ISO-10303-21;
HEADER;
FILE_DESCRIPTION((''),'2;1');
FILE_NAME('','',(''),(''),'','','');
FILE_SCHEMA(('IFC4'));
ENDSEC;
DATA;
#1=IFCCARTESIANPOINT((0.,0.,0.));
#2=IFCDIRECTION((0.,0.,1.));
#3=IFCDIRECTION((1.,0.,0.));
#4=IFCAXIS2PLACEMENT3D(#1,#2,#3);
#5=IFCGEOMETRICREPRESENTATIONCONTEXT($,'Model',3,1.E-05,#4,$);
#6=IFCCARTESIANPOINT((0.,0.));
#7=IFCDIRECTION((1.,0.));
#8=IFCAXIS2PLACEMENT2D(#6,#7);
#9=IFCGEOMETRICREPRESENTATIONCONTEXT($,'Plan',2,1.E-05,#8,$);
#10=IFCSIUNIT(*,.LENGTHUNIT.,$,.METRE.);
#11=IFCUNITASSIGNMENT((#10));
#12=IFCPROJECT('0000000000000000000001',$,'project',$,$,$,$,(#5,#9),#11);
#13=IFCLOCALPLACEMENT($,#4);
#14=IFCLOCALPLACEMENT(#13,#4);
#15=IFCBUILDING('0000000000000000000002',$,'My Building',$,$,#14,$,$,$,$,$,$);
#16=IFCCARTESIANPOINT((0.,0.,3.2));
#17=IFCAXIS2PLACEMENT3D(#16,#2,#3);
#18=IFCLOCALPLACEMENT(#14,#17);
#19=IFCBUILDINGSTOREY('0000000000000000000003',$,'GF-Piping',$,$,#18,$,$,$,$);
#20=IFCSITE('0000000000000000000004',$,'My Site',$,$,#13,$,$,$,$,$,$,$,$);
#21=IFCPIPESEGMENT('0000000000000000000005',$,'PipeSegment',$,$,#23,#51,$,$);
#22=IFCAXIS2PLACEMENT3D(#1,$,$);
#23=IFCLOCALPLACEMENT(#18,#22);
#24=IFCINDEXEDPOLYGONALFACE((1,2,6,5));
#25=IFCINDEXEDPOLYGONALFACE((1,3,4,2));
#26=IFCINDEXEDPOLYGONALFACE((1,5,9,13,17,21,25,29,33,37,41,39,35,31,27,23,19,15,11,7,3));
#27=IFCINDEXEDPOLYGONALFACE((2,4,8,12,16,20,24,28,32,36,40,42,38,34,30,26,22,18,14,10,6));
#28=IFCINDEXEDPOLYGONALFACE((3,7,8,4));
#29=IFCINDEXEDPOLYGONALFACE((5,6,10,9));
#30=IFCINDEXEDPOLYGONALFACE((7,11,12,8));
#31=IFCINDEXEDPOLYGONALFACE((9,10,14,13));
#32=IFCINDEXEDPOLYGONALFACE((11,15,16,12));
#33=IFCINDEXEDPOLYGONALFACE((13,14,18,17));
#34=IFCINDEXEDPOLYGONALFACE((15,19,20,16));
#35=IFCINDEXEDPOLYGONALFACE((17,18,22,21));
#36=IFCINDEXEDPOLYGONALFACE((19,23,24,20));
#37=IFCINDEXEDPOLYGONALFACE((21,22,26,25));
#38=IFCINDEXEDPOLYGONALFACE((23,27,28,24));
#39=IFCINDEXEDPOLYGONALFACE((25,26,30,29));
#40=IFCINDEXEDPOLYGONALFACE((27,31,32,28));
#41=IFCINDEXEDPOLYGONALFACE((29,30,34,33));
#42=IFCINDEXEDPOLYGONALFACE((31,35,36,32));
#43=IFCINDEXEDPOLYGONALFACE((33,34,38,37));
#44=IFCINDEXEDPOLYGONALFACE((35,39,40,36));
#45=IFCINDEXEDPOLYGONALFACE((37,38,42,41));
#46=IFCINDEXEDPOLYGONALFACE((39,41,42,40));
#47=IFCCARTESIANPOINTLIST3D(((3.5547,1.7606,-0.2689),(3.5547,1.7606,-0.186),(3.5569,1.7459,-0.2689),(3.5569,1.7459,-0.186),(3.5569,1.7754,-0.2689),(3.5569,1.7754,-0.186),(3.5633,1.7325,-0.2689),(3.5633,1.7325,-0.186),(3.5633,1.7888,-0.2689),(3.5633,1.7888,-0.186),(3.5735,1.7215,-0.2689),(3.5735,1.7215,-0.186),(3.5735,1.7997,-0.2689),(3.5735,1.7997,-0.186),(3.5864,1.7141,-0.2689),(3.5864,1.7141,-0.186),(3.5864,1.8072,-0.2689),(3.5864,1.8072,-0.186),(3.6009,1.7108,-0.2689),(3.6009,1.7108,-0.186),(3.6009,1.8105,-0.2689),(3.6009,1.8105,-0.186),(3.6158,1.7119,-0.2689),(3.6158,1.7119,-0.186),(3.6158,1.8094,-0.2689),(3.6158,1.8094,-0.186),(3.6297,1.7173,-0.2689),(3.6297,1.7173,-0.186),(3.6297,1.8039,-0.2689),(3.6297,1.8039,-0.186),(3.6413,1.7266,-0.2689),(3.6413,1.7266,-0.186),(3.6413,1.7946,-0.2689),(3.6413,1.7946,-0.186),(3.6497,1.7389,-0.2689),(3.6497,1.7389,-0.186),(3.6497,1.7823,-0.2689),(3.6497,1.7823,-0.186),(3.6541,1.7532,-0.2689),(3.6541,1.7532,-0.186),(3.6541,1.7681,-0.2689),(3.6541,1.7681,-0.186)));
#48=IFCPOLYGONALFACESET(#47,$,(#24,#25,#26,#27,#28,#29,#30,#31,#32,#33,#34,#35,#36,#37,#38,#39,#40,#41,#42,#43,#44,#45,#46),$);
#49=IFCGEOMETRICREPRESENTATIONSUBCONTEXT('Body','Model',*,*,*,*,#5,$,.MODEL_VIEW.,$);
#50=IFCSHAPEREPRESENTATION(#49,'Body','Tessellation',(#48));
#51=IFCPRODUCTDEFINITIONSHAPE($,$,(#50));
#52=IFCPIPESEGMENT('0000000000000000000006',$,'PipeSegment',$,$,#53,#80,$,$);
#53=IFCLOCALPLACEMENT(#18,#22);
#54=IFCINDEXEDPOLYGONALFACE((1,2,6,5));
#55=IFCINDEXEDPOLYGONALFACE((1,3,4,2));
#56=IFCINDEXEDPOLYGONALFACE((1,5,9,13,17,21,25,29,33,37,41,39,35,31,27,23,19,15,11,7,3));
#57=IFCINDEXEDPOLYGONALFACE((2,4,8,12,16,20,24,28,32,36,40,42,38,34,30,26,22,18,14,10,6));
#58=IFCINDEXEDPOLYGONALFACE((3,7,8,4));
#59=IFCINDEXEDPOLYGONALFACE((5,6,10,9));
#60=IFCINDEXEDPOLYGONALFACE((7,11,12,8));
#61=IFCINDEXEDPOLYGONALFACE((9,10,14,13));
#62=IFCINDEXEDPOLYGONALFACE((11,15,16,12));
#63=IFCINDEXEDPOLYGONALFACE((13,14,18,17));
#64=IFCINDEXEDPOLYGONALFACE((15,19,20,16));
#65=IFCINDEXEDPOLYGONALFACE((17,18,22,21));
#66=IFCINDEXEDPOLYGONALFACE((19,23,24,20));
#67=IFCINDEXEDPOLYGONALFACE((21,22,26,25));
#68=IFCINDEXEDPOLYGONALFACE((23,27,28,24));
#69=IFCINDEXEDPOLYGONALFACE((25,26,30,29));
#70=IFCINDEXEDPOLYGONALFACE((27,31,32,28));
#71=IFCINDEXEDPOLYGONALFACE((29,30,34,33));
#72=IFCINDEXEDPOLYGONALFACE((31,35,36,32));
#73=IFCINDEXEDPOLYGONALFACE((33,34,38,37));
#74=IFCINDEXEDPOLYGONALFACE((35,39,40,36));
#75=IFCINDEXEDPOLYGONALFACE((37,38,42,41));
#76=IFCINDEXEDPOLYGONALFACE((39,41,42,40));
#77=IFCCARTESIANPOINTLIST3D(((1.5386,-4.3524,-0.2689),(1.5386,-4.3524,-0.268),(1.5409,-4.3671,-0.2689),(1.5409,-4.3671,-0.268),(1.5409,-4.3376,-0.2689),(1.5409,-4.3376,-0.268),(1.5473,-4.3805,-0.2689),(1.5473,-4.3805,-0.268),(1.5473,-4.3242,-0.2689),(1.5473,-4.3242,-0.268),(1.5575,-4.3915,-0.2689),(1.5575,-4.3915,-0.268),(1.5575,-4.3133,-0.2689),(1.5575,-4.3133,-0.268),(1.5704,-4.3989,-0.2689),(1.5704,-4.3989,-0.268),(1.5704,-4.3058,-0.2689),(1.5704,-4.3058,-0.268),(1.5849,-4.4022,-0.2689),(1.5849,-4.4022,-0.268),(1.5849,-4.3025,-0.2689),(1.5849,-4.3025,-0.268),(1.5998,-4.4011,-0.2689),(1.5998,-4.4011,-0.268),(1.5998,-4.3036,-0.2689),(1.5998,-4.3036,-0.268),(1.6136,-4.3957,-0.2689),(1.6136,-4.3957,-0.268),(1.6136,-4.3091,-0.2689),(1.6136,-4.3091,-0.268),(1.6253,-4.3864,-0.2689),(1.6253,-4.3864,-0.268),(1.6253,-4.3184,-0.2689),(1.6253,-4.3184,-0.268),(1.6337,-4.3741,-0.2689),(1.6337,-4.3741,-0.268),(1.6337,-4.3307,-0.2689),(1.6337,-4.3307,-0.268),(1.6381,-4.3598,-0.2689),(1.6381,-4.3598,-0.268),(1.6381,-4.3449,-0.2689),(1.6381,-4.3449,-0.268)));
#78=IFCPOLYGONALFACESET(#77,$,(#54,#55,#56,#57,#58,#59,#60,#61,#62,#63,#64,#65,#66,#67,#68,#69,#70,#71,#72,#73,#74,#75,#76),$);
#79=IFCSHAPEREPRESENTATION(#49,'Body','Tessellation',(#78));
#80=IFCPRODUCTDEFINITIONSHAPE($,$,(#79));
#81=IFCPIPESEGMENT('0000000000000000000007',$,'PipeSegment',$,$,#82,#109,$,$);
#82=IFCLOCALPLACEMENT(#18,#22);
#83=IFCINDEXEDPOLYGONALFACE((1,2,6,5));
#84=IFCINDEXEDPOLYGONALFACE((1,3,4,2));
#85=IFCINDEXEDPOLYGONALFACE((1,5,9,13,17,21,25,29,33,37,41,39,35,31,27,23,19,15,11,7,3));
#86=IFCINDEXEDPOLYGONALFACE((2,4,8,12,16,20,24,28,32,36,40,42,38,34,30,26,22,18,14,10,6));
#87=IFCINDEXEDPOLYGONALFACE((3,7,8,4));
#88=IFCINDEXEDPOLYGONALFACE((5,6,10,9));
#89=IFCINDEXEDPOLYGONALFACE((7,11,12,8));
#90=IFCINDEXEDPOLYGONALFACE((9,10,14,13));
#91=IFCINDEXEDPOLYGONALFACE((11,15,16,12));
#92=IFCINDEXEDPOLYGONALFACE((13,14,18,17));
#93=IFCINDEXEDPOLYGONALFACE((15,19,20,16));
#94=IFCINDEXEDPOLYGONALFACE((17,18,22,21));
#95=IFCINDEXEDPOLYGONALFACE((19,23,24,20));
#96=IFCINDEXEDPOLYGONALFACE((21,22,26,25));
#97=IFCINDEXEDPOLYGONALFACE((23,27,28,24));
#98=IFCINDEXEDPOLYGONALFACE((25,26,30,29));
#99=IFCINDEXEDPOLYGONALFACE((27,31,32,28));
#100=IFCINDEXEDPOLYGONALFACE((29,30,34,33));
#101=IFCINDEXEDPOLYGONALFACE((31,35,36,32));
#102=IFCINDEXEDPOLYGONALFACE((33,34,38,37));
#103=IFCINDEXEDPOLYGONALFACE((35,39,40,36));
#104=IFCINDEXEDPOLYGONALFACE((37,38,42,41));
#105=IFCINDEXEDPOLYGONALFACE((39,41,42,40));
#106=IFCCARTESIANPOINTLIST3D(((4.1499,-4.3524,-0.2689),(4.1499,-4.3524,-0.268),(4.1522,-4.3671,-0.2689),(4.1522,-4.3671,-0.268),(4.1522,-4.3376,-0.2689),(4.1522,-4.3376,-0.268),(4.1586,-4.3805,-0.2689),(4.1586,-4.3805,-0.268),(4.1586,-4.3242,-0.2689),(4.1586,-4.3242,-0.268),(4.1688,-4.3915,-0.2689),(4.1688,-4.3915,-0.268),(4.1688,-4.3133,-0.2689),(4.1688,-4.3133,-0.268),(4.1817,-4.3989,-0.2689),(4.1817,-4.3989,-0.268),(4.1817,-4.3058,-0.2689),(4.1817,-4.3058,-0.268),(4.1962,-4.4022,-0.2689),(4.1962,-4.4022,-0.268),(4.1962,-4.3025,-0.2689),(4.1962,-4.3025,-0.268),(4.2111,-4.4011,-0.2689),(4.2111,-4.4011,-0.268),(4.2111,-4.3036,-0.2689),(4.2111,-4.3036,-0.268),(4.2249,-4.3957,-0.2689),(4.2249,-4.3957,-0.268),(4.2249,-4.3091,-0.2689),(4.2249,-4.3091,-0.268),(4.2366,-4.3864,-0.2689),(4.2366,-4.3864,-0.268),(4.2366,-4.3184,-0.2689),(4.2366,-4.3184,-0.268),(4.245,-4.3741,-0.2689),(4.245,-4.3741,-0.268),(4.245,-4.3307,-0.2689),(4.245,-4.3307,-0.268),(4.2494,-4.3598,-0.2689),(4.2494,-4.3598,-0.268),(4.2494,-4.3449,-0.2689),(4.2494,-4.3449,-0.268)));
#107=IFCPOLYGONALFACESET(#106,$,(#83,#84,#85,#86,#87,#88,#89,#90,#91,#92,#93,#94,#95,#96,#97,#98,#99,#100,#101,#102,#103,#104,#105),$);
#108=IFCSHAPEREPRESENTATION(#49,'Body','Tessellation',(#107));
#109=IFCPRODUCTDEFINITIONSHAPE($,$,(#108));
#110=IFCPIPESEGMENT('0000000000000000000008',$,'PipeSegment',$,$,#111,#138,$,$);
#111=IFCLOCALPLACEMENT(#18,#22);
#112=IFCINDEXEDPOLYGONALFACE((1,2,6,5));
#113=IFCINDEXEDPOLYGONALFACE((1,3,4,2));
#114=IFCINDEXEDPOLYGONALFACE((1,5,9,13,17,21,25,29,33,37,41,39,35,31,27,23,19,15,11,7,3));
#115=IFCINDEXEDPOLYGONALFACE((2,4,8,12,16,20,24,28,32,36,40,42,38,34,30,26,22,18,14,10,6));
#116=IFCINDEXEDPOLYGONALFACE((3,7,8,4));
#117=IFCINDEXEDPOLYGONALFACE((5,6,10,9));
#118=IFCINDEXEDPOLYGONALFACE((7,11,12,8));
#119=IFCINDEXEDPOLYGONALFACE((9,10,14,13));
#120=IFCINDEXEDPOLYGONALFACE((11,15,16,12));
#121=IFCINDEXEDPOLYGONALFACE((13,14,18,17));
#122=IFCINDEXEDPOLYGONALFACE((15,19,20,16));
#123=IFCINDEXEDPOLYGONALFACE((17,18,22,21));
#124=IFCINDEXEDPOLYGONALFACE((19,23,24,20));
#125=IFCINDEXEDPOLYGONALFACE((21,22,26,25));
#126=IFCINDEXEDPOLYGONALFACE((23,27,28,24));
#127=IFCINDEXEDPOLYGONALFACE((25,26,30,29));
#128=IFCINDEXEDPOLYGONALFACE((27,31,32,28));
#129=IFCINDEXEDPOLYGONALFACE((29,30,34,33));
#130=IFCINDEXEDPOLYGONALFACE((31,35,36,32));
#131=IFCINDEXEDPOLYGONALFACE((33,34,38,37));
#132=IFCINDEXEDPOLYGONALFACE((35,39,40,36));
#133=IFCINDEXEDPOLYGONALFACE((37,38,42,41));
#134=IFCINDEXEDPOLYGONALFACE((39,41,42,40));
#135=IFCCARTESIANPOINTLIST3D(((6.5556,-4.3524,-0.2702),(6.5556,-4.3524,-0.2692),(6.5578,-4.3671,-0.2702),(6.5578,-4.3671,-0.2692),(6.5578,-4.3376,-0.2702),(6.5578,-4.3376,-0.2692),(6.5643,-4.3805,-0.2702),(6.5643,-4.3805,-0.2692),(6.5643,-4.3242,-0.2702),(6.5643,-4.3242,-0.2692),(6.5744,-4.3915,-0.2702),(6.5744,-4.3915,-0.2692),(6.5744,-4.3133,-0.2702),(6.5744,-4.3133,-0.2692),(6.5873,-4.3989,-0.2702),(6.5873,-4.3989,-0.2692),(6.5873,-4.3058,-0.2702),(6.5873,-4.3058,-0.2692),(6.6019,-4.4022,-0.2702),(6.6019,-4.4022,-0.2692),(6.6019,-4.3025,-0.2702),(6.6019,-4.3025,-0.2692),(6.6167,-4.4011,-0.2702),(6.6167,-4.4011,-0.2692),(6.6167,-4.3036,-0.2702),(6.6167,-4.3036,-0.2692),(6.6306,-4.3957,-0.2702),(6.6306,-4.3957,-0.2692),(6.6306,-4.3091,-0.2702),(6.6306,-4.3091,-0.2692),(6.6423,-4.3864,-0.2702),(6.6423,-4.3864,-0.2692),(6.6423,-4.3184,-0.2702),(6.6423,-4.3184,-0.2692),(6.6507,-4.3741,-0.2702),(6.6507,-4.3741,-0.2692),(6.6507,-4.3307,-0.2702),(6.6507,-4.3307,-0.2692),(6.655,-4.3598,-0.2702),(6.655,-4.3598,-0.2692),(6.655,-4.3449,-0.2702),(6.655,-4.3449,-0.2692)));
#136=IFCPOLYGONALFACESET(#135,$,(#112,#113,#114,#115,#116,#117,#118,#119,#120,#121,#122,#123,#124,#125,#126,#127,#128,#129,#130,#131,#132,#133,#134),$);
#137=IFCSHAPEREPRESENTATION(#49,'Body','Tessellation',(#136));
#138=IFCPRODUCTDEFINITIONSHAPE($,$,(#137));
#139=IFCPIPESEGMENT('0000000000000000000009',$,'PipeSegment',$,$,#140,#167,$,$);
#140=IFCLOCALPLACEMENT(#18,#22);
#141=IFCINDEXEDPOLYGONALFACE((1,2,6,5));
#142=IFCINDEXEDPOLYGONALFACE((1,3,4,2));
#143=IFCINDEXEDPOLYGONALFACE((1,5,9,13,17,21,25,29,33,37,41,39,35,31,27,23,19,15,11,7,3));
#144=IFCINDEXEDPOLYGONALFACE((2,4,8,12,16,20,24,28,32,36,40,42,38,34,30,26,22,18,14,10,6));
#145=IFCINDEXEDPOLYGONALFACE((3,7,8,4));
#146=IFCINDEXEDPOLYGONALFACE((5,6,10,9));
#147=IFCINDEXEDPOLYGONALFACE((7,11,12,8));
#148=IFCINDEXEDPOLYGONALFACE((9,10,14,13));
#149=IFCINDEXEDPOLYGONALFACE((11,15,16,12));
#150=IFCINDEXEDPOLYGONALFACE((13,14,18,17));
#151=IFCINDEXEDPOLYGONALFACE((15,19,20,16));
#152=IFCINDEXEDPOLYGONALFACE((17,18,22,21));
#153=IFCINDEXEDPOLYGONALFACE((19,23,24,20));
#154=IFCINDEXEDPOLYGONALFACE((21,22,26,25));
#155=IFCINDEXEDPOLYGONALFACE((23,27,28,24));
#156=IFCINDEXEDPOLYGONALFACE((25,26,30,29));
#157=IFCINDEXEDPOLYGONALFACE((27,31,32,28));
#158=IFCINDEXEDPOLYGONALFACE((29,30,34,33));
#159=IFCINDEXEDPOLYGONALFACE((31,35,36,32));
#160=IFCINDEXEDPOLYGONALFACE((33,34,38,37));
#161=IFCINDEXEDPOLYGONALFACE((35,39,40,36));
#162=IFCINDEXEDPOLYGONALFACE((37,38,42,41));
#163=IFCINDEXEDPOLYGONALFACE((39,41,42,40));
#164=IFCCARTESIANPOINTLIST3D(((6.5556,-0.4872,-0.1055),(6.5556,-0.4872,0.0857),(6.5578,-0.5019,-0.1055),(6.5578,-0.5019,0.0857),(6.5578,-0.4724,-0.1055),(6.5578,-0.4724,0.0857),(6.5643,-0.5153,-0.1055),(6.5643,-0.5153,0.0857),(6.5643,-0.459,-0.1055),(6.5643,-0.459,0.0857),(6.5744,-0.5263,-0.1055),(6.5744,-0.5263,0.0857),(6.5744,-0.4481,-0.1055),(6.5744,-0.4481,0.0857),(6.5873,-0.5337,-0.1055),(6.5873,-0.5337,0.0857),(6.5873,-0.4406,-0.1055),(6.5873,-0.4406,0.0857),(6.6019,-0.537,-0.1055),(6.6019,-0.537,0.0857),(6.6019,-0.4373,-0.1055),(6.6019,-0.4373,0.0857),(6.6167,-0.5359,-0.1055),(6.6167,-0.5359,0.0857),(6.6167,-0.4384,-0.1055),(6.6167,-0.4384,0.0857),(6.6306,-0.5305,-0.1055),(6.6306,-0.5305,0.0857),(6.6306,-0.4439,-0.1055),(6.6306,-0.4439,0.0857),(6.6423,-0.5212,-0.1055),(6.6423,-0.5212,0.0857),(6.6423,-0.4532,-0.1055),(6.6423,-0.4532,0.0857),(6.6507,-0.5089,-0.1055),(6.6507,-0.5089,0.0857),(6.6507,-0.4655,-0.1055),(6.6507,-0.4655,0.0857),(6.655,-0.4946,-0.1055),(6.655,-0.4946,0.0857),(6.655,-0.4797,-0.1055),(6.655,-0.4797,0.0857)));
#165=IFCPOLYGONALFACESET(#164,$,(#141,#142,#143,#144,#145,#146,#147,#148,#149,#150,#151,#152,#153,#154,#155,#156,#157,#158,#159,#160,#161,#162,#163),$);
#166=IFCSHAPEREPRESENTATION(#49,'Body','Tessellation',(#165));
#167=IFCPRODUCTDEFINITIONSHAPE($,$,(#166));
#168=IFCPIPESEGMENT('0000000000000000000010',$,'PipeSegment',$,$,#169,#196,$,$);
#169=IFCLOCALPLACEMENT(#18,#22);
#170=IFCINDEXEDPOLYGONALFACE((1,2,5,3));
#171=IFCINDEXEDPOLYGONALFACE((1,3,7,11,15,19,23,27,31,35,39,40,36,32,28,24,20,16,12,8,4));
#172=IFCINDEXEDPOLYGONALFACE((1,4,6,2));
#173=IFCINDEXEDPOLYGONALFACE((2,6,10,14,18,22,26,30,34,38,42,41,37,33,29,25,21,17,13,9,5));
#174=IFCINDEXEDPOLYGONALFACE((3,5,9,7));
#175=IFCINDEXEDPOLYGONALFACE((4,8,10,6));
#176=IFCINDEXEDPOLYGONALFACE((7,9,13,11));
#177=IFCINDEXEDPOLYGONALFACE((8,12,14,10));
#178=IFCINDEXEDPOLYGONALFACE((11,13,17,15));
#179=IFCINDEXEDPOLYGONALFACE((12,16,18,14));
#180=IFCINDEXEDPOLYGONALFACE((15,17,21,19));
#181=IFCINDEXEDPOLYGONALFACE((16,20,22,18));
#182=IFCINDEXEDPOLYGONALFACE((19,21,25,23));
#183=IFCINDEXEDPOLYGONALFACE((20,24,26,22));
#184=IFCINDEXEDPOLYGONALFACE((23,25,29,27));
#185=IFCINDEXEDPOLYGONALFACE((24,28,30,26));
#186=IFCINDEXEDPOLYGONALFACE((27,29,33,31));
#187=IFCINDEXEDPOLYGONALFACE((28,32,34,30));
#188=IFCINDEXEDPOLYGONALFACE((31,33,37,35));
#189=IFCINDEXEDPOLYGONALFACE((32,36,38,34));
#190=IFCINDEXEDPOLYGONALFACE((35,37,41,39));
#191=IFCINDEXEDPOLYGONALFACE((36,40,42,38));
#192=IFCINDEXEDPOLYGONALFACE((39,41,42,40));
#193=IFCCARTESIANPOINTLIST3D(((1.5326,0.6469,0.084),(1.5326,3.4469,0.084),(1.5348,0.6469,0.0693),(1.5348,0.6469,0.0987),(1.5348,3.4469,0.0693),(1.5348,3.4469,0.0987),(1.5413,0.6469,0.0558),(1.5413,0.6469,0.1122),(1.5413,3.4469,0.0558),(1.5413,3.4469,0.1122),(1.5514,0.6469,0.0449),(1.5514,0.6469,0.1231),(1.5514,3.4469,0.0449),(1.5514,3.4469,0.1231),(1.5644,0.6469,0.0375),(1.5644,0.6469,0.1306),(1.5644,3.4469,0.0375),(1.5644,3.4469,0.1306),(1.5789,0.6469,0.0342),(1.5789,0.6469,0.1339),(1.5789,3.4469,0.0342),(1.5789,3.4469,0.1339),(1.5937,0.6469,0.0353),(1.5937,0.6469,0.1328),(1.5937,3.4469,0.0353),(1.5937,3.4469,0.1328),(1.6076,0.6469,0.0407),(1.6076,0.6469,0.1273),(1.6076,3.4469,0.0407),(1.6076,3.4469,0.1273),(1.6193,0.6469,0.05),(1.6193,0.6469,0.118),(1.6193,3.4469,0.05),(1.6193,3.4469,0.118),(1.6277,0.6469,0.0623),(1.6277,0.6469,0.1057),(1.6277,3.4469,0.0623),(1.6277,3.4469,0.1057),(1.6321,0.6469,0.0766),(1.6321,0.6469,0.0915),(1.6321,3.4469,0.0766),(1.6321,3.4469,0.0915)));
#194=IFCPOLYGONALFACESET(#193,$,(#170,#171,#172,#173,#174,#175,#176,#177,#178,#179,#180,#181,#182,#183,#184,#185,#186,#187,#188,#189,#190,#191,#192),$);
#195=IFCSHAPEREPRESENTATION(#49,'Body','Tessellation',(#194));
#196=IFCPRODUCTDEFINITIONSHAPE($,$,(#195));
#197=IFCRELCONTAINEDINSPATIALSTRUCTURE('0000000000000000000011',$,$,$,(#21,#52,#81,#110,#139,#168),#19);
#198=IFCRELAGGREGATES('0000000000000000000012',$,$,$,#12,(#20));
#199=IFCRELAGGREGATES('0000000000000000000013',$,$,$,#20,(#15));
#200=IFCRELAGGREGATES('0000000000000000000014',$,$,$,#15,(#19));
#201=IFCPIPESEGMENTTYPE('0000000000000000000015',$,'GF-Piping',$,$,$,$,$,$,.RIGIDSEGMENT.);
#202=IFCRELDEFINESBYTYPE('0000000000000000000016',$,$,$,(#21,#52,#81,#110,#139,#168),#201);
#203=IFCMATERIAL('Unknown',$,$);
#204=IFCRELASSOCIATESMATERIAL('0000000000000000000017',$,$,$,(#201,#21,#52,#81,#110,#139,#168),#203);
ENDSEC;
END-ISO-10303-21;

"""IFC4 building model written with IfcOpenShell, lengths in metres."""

from ifc_helpers import new_model, si_unit, frame, origin_with_axes, origin_2d_with_axis, place, context, subcontext, project, spatial, circle, extrude, material, material_profile, profile_set, profile_usage, type_object, element, save


model = new_model("IFC4")

# Units and contexts
model_context = context("Model", 3, precision=1e-05, world=origin_with_axes())
plan_context = context("Plan", 2, precision=1e-05, world=origin_2d_with_axis())
body_context = subcontext(model_context, "Body", "Model", "MODEL_VIEW")
ifc_project = project(units=[si_unit("LENGTHUNIT", "METRE")], contexts=[model_context, plan_context])

# Site, building, storey
site_placement = place(None, origin_with_axes())
site = spatial("IfcSite", under=ifc_project, at=site_placement, Name="My Site")
building_placement = place(site_placement, origin_with_axes())
building = spatial("IfcBuilding", under=site, at=building_placement, Name="My Building")
storey_placement = place(building_placement, frame((0.0, 0.0, 3.2), z_axis=(0.0, 0.0, 1.0), x_axis=(1.0, 0.0, 0.0)))
storey = spatial("IfcBuildingStorey", under=building, at=storey_placement, Name="GF-Piping")

# Pipe segments
ifc_material = material(Name="Unknown")
ifc_material_profile = material_profile(ifc_material, circle(Radius=0.05))
ifc_profile_set = profile_set([ifc_material_profile])
pipe_segment_type = type_object("IfcPipeSegmentType", Name="GF-Piping", PredefinedType="RIGIDSEGMENT", material=ifc_profile_set)
ifc_profile_usage_1 = profile_usage(ifc_profile_set, cardinal=5)
pipe_segment_1_placement = place(storey_placement, frame((3.6047, 1.7606, -0.186), z_axis=(0.0, 0.0, -1.0), x_axis=(-1.0, 0.0, 0.0)))
element("IfcPipeSegment", 1, at=pipe_segment_1_placement, inside=storey, type_object=pipe_segment_type, material=ifc_profile_usage_1, Name="PipeSegment", context=body_context, shape_type="SweptSolid", body=[
    extrude(circle(Radius=0.05), origin_with_axes(), (0.0, 0.0, 1.0), 0.0828),
])
ifc_profile_usage_2 = profile_usage(ifc_profile_set, cardinal=5)
pipe_segment_2_placement = place(storey_placement, frame((1.5886, -4.3524, -0.268), z_axis=(0.0, 0.0, -1.0), x_axis=(-1.0, 0.0, 0.0)))
element("IfcPipeSegment", 2, at=pipe_segment_2_placement, inside=storey, type_object=pipe_segment_type, material=ifc_profile_usage_2, Name="PipeSegment", context=body_context, shape_type="SweptSolid", body=[
    extrude(circle(Radius=0.05), origin_with_axes(), (0.0, 0.0, 1.0), 0.0009),
])
ifc_profile_usage_3 = profile_usage(ifc_profile_set, cardinal=5)
pipe_segment_3_placement = place(storey_placement, frame((4.1999, -4.3524, -0.268), z_axis=(0.0, 0.0, -1.0), x_axis=(-1.0, 0.0, 0.0)))
element("IfcPipeSegment", 3, at=pipe_segment_3_placement, inside=storey, type_object=pipe_segment_type, material=ifc_profile_usage_3, Name="PipeSegment", context=body_context, shape_type="SweptSolid", body=[
    extrude(circle(Radius=0.05), origin_with_axes(), (0.0, 0.0, 1.0), 0.0009),
])
ifc_profile_usage_4 = profile_usage(ifc_profile_set, cardinal=5)
pipe_segment_4_placement = place(storey_placement, frame((6.6056, -4.3524, -0.2692), z_axis=(0.0, 0.0, -1.0), x_axis=(-1.0, 0.0, 0.0)))
element("IfcPipeSegment", 4, at=pipe_segment_4_placement, inside=storey, type_object=pipe_segment_type, material=ifc_profile_usage_4, Name="PipeSegment", context=body_context, shape_type="SweptSolid", body=[
    extrude(circle(Radius=0.05), origin_with_axes(), (0.0, 0.0, 1.0), 0.0009),
])
ifc_profile_usage_5 = profile_usage(ifc_profile_set, cardinal=5)
pipe_segment_5_placement = place(storey_placement, frame((6.6056, -0.4872, 0.0857), z_axis=(0.0, 0.0, -1.0), x_axis=(-1.0, 0.0, 0.0)))
element("IfcPipeSegment", 5, at=pipe_segment_5_placement, inside=storey, type_object=pipe_segment_type, material=ifc_profile_usage_5, Name="PipeSegment", context=body_context, shape_type="SweptSolid", body=[
    extrude(circle(Radius=0.05), origin_with_axes(), (0.0, 0.0, 1.0), 0.1912),
])
ifc_profile_usage_6 = profile_usage(ifc_profile_set, cardinal=5)
pipe_segment_6_placement = place(storey_placement, frame((1.5826, 0.6469, 0.084), z_axis=(0.0, 1.0, 0.0), x_axis=(-1.0, 0.0, 0.0)))
element("IfcPipeSegment", 6, at=pipe_segment_6_placement, inside=storey, type_object=pipe_segment_type, material=ifc_profile_usage_6, Name="PipeSegment", context=body_context, shape_type="SweptSolid", body=[
    extrude(circle(Radius=0.05), origin_with_axes(), (0.0, 0.0, 1.0), 2.8),
])

save(model, "model.ifc")
